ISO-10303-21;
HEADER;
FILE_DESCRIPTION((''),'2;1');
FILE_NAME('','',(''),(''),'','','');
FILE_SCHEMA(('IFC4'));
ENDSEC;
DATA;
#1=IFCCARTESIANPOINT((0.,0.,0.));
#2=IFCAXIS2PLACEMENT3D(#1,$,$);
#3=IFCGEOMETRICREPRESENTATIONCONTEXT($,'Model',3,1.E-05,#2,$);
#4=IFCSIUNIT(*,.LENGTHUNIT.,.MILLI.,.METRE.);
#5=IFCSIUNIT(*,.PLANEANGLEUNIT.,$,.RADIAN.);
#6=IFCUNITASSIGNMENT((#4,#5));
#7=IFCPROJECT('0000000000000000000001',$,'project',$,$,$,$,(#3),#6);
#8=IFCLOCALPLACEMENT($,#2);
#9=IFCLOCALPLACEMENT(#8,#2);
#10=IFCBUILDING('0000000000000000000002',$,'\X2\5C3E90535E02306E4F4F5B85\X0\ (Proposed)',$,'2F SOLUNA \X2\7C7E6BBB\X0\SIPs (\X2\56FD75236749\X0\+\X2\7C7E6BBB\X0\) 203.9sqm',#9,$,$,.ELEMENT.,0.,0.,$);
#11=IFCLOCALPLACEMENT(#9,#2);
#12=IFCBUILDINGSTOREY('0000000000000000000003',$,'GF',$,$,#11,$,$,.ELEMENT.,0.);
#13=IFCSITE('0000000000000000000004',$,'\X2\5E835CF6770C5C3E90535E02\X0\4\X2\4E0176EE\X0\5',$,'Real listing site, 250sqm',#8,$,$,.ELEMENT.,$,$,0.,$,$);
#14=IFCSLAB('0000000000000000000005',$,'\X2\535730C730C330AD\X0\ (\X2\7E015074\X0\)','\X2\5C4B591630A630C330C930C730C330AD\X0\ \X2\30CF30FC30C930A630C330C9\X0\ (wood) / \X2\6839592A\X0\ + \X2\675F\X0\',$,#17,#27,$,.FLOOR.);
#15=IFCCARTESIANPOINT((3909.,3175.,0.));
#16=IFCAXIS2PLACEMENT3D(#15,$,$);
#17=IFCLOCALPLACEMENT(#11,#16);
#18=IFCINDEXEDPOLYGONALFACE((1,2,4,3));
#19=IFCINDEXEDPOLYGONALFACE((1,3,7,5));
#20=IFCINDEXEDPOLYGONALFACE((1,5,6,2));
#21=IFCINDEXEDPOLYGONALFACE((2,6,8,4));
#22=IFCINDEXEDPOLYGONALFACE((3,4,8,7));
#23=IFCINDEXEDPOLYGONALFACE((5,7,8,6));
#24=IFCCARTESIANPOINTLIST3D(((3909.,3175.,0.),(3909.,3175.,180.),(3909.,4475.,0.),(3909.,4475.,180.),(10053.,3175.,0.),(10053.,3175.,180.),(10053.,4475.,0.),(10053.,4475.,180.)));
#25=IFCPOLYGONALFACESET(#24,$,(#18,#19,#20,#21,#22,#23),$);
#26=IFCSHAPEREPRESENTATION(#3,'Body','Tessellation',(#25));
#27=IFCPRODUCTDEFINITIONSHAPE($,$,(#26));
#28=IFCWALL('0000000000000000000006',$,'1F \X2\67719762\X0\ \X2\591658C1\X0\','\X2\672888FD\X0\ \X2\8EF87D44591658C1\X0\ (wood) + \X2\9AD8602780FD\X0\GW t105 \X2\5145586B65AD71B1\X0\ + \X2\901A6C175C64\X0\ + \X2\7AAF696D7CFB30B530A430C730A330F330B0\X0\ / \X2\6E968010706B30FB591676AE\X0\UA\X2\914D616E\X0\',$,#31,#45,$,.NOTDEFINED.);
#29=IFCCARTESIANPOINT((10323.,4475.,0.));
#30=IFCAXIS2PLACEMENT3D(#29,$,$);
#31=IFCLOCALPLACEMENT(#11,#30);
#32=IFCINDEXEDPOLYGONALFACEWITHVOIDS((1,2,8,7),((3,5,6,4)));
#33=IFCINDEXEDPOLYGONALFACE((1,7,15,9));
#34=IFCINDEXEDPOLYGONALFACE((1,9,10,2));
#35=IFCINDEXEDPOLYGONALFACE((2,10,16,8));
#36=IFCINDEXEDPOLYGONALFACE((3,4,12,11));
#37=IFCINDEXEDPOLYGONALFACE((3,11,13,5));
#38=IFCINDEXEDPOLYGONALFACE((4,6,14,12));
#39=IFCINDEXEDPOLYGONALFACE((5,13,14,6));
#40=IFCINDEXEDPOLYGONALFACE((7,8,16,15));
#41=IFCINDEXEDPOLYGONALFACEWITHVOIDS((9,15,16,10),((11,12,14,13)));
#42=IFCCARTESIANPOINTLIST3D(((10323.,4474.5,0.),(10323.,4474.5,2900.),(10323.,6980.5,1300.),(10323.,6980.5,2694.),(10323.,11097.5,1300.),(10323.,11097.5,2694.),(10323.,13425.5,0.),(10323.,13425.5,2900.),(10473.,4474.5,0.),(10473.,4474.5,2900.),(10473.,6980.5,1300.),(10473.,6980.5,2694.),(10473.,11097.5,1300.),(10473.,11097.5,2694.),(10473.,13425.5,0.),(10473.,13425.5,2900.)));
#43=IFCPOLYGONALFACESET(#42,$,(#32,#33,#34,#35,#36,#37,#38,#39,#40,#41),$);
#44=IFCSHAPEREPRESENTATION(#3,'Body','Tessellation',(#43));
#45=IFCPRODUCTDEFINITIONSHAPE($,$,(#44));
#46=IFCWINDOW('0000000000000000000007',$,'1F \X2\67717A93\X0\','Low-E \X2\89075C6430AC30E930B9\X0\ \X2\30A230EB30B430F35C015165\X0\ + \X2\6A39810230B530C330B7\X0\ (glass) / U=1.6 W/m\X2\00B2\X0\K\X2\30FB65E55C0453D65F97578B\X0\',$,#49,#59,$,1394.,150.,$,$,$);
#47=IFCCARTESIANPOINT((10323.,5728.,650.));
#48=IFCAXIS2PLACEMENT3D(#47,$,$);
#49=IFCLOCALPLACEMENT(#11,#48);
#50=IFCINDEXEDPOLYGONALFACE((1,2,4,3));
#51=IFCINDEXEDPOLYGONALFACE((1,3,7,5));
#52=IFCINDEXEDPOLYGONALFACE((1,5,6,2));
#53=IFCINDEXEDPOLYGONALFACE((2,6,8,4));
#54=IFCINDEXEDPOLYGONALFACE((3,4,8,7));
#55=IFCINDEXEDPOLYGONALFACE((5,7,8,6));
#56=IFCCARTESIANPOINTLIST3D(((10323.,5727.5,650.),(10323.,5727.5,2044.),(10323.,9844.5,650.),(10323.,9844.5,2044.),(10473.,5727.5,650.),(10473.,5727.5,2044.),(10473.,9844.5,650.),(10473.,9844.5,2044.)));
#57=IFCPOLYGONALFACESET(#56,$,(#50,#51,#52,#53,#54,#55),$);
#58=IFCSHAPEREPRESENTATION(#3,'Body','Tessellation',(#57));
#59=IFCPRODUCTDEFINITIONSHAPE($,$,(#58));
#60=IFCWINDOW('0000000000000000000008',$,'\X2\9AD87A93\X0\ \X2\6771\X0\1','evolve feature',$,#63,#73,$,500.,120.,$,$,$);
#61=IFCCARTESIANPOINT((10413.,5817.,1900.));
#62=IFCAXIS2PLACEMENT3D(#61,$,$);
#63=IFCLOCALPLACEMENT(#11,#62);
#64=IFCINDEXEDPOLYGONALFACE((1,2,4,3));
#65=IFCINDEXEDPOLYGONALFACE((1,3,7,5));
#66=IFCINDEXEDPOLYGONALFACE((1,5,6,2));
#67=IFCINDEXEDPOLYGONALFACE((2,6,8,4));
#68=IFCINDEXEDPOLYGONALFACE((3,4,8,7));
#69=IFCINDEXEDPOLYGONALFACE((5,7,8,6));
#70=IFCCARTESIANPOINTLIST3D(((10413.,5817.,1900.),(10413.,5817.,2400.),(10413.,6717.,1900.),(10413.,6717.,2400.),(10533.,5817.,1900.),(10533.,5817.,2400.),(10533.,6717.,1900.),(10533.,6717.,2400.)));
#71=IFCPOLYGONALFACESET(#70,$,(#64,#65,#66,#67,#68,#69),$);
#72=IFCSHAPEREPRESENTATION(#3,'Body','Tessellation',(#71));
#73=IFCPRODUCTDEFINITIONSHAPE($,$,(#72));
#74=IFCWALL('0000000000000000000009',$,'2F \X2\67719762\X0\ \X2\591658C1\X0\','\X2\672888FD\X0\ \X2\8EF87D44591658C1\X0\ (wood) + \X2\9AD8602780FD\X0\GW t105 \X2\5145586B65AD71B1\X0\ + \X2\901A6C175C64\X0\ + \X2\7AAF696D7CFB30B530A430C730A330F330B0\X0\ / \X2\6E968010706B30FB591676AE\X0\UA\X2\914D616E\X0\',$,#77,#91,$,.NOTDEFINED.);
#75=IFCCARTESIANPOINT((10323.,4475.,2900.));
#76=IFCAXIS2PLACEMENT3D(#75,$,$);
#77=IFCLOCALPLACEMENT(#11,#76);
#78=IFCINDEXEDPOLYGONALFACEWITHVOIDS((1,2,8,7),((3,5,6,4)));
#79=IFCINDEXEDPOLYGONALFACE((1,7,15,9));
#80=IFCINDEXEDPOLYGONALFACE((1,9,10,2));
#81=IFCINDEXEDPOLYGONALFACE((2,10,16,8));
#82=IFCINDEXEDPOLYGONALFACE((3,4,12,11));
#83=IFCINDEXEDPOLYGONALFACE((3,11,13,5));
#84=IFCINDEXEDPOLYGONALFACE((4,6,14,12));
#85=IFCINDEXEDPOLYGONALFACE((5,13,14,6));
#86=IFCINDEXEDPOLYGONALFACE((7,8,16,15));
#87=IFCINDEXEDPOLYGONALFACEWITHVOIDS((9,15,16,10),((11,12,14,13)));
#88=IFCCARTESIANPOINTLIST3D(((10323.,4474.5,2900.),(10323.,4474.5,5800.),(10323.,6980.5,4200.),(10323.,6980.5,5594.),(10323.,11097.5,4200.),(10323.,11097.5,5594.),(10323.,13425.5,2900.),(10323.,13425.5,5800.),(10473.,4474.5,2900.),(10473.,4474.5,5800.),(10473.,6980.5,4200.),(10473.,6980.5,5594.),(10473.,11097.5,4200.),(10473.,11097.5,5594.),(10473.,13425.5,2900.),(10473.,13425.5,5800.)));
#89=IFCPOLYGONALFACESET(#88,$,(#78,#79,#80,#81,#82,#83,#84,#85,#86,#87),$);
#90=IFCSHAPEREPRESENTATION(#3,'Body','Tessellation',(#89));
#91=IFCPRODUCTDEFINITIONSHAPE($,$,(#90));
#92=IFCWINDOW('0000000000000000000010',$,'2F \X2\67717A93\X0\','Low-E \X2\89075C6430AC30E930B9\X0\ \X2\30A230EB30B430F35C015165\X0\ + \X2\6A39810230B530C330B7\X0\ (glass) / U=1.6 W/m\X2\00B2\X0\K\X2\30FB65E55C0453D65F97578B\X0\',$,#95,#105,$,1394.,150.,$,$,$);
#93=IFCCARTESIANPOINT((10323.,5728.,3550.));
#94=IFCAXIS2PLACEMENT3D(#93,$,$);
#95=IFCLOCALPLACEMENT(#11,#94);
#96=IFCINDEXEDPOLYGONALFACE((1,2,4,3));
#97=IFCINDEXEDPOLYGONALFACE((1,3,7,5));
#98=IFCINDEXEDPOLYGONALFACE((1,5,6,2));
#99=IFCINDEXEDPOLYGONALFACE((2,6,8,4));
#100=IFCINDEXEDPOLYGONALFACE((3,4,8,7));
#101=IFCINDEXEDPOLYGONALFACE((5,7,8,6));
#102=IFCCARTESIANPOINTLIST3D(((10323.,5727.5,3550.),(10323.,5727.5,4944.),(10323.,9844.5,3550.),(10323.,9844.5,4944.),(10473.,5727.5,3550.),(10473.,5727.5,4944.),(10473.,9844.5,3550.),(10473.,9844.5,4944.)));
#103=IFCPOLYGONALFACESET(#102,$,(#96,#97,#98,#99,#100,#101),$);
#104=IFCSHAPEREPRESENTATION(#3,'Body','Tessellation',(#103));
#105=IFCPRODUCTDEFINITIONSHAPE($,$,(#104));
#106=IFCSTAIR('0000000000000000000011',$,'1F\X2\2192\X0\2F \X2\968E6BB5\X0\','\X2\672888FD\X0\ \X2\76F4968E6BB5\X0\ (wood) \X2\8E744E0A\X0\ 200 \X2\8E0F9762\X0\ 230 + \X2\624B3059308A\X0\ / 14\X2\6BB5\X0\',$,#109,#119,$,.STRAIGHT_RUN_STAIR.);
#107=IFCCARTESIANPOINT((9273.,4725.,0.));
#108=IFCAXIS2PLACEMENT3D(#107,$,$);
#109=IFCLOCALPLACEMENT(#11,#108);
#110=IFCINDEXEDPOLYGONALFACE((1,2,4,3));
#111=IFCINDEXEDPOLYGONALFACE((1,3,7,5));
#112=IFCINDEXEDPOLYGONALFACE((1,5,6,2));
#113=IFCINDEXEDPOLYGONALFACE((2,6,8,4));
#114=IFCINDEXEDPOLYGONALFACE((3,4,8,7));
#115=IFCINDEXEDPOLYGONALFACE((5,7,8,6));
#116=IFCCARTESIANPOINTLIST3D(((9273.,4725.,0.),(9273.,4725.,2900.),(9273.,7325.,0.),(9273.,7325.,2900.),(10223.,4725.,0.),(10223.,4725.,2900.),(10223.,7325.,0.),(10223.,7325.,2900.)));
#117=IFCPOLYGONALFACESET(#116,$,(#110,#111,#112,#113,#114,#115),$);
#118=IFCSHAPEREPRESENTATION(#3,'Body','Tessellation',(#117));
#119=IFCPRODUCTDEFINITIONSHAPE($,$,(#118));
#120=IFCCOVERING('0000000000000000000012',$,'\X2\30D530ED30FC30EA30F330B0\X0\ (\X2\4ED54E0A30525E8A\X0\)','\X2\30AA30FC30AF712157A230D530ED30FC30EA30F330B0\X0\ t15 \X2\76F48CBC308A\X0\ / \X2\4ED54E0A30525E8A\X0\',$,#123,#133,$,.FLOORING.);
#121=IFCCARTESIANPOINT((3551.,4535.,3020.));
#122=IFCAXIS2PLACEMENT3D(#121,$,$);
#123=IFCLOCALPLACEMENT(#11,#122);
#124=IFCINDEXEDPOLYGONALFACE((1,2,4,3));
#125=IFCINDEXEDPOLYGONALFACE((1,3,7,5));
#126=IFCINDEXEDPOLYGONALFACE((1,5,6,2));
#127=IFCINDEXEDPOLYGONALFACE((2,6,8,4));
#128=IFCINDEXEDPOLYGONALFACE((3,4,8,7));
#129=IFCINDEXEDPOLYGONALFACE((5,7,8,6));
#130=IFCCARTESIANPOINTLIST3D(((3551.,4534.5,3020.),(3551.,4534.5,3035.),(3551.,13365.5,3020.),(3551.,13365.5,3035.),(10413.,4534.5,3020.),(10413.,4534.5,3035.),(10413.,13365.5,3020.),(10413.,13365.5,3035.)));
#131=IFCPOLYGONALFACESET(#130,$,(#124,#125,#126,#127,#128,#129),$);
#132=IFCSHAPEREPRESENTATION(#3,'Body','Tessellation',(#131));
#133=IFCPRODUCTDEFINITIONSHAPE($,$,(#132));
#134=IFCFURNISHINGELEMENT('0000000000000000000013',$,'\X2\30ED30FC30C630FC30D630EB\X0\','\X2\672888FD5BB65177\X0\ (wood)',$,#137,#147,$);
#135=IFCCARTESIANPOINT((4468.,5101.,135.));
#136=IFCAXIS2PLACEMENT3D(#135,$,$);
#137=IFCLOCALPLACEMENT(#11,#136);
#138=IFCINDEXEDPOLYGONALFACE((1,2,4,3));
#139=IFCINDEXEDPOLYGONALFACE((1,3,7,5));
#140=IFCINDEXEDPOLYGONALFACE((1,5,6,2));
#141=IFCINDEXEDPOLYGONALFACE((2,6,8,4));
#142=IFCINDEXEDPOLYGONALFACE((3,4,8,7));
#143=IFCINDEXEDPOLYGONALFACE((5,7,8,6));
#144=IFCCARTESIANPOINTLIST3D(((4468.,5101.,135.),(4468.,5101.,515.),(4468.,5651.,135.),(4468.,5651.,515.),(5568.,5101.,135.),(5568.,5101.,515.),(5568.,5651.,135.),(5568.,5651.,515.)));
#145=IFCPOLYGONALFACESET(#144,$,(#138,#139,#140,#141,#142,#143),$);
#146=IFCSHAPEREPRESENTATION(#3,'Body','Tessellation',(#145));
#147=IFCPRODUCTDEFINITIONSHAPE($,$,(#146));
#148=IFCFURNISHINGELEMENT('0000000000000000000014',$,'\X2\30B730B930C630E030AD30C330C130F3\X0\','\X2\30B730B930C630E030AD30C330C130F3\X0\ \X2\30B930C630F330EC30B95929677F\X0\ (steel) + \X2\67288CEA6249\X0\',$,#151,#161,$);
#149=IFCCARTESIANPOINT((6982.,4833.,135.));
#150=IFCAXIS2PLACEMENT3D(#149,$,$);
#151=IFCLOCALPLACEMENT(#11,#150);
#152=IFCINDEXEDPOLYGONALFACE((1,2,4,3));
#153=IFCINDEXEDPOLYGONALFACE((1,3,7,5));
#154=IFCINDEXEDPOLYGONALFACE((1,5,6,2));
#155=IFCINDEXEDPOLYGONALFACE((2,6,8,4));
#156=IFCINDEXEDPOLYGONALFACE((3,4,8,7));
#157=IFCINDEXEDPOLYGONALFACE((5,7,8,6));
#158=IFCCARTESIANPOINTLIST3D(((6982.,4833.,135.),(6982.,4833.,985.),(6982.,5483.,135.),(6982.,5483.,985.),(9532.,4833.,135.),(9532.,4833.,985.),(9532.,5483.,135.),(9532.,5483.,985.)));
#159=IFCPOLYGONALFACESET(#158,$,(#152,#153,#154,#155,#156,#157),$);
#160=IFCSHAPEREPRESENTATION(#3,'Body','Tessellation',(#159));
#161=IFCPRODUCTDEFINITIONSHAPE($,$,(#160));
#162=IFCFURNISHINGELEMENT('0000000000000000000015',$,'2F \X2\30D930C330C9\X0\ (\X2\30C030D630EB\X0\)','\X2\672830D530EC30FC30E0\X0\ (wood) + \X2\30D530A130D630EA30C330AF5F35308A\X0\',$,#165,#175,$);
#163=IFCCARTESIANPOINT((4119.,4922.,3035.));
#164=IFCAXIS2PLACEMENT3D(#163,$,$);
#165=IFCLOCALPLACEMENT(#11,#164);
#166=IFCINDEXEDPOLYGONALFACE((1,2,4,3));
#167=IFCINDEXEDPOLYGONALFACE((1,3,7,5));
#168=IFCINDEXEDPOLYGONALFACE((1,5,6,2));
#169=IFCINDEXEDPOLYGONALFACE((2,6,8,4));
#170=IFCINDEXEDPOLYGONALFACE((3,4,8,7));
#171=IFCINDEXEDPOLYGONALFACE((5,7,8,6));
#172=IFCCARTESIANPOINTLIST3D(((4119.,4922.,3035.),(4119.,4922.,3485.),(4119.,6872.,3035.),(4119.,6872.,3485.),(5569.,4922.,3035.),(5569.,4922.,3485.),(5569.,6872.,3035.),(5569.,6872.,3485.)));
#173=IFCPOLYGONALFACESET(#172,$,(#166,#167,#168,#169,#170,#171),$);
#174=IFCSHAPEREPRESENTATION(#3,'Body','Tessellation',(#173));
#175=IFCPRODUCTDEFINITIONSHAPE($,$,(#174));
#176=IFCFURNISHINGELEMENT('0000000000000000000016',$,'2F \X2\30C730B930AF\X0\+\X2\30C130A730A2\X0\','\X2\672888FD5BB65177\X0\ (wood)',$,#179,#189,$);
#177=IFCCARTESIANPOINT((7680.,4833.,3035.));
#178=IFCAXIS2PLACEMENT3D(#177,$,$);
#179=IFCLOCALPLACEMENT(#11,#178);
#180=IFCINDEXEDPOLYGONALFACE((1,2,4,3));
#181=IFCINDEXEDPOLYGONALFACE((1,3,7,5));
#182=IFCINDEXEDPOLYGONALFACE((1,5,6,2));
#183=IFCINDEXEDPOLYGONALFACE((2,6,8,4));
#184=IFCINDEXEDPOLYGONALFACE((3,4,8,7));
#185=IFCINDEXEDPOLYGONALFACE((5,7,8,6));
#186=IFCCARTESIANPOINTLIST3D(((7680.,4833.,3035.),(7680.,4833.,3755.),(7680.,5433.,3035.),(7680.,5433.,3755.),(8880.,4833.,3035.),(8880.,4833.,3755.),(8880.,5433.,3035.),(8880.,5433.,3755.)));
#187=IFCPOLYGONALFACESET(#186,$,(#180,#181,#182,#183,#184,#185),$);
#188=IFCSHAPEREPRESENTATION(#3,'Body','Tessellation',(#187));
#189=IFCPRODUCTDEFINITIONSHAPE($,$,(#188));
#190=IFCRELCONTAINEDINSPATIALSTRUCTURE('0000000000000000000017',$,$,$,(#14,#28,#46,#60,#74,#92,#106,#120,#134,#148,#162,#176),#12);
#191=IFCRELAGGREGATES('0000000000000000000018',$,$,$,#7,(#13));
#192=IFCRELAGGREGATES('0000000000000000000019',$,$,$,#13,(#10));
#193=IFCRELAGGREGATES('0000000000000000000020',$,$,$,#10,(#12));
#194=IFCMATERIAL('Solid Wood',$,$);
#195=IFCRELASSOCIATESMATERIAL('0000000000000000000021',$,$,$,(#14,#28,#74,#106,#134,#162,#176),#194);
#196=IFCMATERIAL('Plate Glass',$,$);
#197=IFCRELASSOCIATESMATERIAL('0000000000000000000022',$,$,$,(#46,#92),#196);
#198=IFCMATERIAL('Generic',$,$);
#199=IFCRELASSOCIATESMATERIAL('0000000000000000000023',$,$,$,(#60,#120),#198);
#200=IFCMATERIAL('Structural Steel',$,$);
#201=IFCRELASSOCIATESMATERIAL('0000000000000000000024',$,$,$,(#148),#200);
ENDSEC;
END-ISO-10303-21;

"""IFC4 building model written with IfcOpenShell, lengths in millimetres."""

from ifc_helpers import new_model, si_unit, frame, frame_2d, origin, place, context, project, spatial, rectangle, extrude, material, element, fill, save


model = new_model("IFC4")

# Units and contexts
model_context = context("Model", 3, precision=1e-05, world=origin())
ifc_project = project(units=[si_unit("LENGTHUNIT", "METRE", prefix="MILLI"), si_unit("PLANEANGLEUNIT", "RADIAN")], contexts=[model_context])

# Site, building, storey
site_placement = place(None, origin())
site = spatial("IfcSite", under=ifc_project, at=site_placement, Name="広島県尾道市4丁目5", ObjectType="Real listing site, 250sqm", CompositionType="ELEMENT", RefElevation=0.0)
building_placement = place(site_placement, origin())
building = spatial("IfcBuilding", under=site, at=building_placement, Name="尾道市の住宅 (Proposed)", ObjectType="2F SOLUNA 籾殻SIPs (国産杉+籾殻) 203.9sqm", CompositionType="ELEMENT", ElevationOfRefHeight=0.0, ElevationOfTerrain=0.0)
storey_placement = place(building_placement, origin())
storey = spatial("IfcBuildingStorey", under=building, at=storey_placement, Name="GF", CompositionType="ELEMENT", Elevation=0.0)

# Slab
ifc_material_1 = material(Name="Solid Wood")
slab_placement = place(storey_placement, frame((3909.0, 3175.0, 0.0)))
element("IfcSlab", 1, at=slab_placement, inside=storey, material=ifc_material_1, Name="南デッキ (縁側)", Description="屋外ウッドデッキ ハードウッド (wood) / 根太 + 束", PredefinedType="FLOOR", context=model_context, shape_type="SweptSolid", body=[
    extrude(rectangle(XDim=6144.0, YDim=1300.0, at=frame_2d((3072.0, 650.0))), frame((3909.0, 3175.0, 0.0)), (0.0, 0.0, 1.0), 180.0),
])

# Wall, openings, windows
wall_1_placement = place(storey_placement, frame((10323.0, 4475.0, 0.0)))
wall_1 = element("IfcWall", 2, at=wall_1_placement, inside=storey, material=ifc_material_1, Name="1F 東面 外壁", Description="木製 軸組外壁 (wood) + 高性能GW t105 充填断熱 + 通気層 + 窯業系サイディング / 準耐火・外皮UA配慮", PredefinedType="NOTDEFINED", context=model_context, shape_type="SweptSolid", body=[
    extrude(rectangle(XDim=150.0, YDim=8951.0, at=frame_2d((75.0, 4475.0))), frame((10323.0, 4475.0, 0.0)), (0.0, 0.0, 1.0), 2900.0),
])
opening_1_placement = place(storey_placement, frame((10323.0, 5728.0, 650.0)))
opening_1 = element("IfcOpeningElement", 3, at=opening_1_placement, cuts=wall_1, PredefinedType="NOTDEFINED", context=model_context, shape_type="SweptSolid", body=[
    extrude(rectangle(XDim=150.0, YDim=4117.0, at=frame_2d((75.0, 2058.0))), frame((10323.0, 5728.0, 650.0)), (0.0, 0.0, 1.0), 1394.0),
])
opening_2_placement = place(storey_placement, frame((10413.0, 5817.0, 1900.0)))
opening_2 = element("IfcOpeningElement", 4, at=opening_2_placement, cuts=wall_1, PredefinedType="NOTDEFINED", context=model_context, shape_type="SweptSolid", body=[
    extrude(rectangle(XDim=120.0, YDim=900.0, at=frame_2d((60.0, 450.0))), frame((10413.0, 5817.0, 1900.0)), (0.0, 0.0, 1.0), 500.0),
])
ifc_material_2 = material(Name="Plate Glass")
window_1_placement = place(storey_placement, frame((10323.0, 5728.0, 650.0)))
window_1 = element("IfcWindow", 5, at=window_1_placement, inside=storey, material=ifc_material_2, Name="1F 東窓", Description="Low-E 複層ガラス アルゴン封入 + 樹脂サッシ (glass) / U=1.6 W/m²K・日射取得型", OverallHeight=1394.0, OverallWidth=150.0, context=model_context, shape_type="SweptSolid", body=[
    extrude(rectangle(XDim=150.0, YDim=4117.0, at=frame_2d((75.0, 2058.0))), frame((10323.0, 5728.0, 650.0)), (0.0, 0.0, 1.0), 1394.0),
])
fill(opening_1, window_1)
ifc_material_3 = material(Name="Generic")
window_2_placement = place(storey_placement, frame((10413.0, 5817.0, 1900.0)))
window_2 = element("IfcWindow", 6, at=window_2_placement, inside=storey, material=ifc_material_3, Name="高窓 東1", Description="evolve feature", OverallHeight=500.0, OverallWidth=120.0, context=model_context, shape_type="SweptSolid", body=[
    extrude(rectangle(XDim=120.0, YDim=900.0, at=frame_2d((60.0, 450.0))), frame((10413.0, 5817.0, 1900.0)), (0.0, 0.0, 1.0), 500.0),
])
fill(opening_2, window_2)

# Wall, opening, window
wall_2_placement = place(storey_placement, frame((10323.0, 4475.0, 2900.0)))
wall_2 = element("IfcWall", 7, at=wall_2_placement, inside=storey, material=ifc_material_1, Name="2F 東面 外壁", Description="木製 軸組外壁 (wood) + 高性能GW t105 充填断熱 + 通気層 + 窯業系サイディング / 準耐火・外皮UA配慮", PredefinedType="NOTDEFINED", context=model_context, shape_type="SweptSolid", body=[
    extrude(rectangle(XDim=150.0, YDim=8951.0, at=frame_2d((75.0, 4475.0))), frame((10323.0, 4475.0, 2900.0)), (0.0, 0.0, 1.0), 2900.0),
])
opening_3_placement = place(storey_placement, frame((10323.0, 5728.0, 3550.0)))
opening_3 = element("IfcOpeningElement", 8, at=opening_3_placement, cuts=wall_2, PredefinedType="NOTDEFINED", context=model_context, shape_type="SweptSolid", body=[
    extrude(rectangle(XDim=150.0, YDim=4117.0, at=frame_2d((75.0, 2058.0))), frame((10323.0, 5728.0, 3550.0)), (0.0, 0.0, 1.0), 1394.0),
])
window_3_placement = place(storey_placement, frame((10323.0, 5728.0, 3550.0)))
window_3 = element("IfcWindow", 9, at=window_3_placement, inside=storey, material=ifc_material_2, Name="2F 東窓", Description="Low-E 複層ガラス アルゴン封入 + 樹脂サッシ (glass) / U=1.6 W/m²K・日射取得型", OverallHeight=1394.0, OverallWidth=150.0, context=model_context, shape_type="SweptSolid", body=[
    extrude(rectangle(XDim=150.0, YDim=4117.0, at=frame_2d((75.0, 2058.0))), frame((10323.0, 5728.0, 3550.0)), (0.0, 0.0, 1.0), 1394.0),
])
fill(opening_3, window_3)

# Stair
stair_placement = place(storey_placement, frame((9273.0, 4725.0, 0.0)))
element("IfcStair", 10, at=stair_placement, inside=storey, material=ifc_material_1, Name="1F→2F 階段", Description="木製 直階段 (wood) 蹴上 200 踏面 230 + 手すり / 14段", PredefinedType="STRAIGHT_RUN_STAIR", context=model_context, shape_type="SweptSolid", body=[
    extrude(rectangle(XDim=950.0, YDim=2600.0, at=frame_2d((475.0, 1300.0))), frame((9273.0, 4725.0, 0.0)), (0.0, 0.0, 1.0), 2900.0),
])

# Covering
covering_placement = place(storey_placement, frame((3551.0, 4535.0, 3020.0)))
element("IfcCovering", 11, at=covering_placement, inside=storey, material=ifc_material_3, Name="フローリング (仕上げ床)", Description="オーク無垢フローリング t15 直貼り / 仕上げ床", PredefinedType="FLOORING", context=model_context, shape_type="SweptSolid", body=[
    extrude(rectangle(XDim=6862.0, YDim=8831.0, at=frame_2d((3431.0, 4415.0))), frame((3551.0, 4535.0, 3020.0)), (0.0, 0.0, 1.0), 15.0),
])

# Furnishing elements
furnishing_1_placement = place(storey_placement, frame((4468.0, 5101.0, 135.0)))
element("IfcFurnishingElement", 12, at=furnishing_1_placement, inside=storey, material=ifc_material_1, Name="ローテーブル", Description="木製家具 (wood)", context=model_context, shape_type="SweptSolid", body=[
    extrude(rectangle(XDim=1100.0, YDim=550.0, at=frame_2d((550.0, 275.0))), frame((4468.0, 5101.0, 135.0)), (0.0, 0.0, 1.0), 380.0),
])
ifc_material_4 = material(Name="Structural Steel")
furnishing_2_placement = place(storey_placement, frame((6982.0, 4833.0, 135.0)))
element("IfcFurnishingElement", 13, at=furnishing_2_placement, inside=storey, material=ifc_material_4, Name="システムキッチン", Description="システムキッチン ステンレス天板 (steel) + 木質扉", context=model_context, shape_type="SweptSolid", body=[
    extrude(rectangle(XDim=2550.0, YDim=650.0, at=frame_2d((1275.0, 325.0))), frame((6982.0, 4833.0, 135.0)), (0.0, 0.0, 1.0), 850.0),
])
furnishing_3_placement = place(storey_placement, frame((4119.0, 4922.0, 3035.0)))
element("IfcFurnishingElement", 14, at=furnishing_3_placement, inside=storey, material=ifc_material_1, Name="2F ベッド (ダブル)", Description="木フレーム (wood) + ファブリック張り", context=model_context, shape_type="SweptSolid", body=[
    extrude(rectangle(XDim=1450.0, YDim=1950.0, at=frame_2d((725.0, 975.0))), frame((4119.0, 4922.0, 3035.0)), (0.0, 0.0, 1.0), 450.0),
])
furnishing_4_placement = place(storey_placement, frame((7680.0, 4833.0, 3035.0)))
element("IfcFurnishingElement", 15, at=furnishing_4_placement, inside=storey, material=ifc_material_1, Name="2F デスク+チェア", Description="木製家具 (wood)", context=model_context, shape_type="SweptSolid", body=[
    extrude(rectangle(XDim=1200.0, YDim=600.0, at=frame_2d((600.0, 300.0))), frame((7680.0, 4833.0, 3035.0)), (0.0, 0.0, 1.0), 720.0),
])

save(model, "model.ifc")
